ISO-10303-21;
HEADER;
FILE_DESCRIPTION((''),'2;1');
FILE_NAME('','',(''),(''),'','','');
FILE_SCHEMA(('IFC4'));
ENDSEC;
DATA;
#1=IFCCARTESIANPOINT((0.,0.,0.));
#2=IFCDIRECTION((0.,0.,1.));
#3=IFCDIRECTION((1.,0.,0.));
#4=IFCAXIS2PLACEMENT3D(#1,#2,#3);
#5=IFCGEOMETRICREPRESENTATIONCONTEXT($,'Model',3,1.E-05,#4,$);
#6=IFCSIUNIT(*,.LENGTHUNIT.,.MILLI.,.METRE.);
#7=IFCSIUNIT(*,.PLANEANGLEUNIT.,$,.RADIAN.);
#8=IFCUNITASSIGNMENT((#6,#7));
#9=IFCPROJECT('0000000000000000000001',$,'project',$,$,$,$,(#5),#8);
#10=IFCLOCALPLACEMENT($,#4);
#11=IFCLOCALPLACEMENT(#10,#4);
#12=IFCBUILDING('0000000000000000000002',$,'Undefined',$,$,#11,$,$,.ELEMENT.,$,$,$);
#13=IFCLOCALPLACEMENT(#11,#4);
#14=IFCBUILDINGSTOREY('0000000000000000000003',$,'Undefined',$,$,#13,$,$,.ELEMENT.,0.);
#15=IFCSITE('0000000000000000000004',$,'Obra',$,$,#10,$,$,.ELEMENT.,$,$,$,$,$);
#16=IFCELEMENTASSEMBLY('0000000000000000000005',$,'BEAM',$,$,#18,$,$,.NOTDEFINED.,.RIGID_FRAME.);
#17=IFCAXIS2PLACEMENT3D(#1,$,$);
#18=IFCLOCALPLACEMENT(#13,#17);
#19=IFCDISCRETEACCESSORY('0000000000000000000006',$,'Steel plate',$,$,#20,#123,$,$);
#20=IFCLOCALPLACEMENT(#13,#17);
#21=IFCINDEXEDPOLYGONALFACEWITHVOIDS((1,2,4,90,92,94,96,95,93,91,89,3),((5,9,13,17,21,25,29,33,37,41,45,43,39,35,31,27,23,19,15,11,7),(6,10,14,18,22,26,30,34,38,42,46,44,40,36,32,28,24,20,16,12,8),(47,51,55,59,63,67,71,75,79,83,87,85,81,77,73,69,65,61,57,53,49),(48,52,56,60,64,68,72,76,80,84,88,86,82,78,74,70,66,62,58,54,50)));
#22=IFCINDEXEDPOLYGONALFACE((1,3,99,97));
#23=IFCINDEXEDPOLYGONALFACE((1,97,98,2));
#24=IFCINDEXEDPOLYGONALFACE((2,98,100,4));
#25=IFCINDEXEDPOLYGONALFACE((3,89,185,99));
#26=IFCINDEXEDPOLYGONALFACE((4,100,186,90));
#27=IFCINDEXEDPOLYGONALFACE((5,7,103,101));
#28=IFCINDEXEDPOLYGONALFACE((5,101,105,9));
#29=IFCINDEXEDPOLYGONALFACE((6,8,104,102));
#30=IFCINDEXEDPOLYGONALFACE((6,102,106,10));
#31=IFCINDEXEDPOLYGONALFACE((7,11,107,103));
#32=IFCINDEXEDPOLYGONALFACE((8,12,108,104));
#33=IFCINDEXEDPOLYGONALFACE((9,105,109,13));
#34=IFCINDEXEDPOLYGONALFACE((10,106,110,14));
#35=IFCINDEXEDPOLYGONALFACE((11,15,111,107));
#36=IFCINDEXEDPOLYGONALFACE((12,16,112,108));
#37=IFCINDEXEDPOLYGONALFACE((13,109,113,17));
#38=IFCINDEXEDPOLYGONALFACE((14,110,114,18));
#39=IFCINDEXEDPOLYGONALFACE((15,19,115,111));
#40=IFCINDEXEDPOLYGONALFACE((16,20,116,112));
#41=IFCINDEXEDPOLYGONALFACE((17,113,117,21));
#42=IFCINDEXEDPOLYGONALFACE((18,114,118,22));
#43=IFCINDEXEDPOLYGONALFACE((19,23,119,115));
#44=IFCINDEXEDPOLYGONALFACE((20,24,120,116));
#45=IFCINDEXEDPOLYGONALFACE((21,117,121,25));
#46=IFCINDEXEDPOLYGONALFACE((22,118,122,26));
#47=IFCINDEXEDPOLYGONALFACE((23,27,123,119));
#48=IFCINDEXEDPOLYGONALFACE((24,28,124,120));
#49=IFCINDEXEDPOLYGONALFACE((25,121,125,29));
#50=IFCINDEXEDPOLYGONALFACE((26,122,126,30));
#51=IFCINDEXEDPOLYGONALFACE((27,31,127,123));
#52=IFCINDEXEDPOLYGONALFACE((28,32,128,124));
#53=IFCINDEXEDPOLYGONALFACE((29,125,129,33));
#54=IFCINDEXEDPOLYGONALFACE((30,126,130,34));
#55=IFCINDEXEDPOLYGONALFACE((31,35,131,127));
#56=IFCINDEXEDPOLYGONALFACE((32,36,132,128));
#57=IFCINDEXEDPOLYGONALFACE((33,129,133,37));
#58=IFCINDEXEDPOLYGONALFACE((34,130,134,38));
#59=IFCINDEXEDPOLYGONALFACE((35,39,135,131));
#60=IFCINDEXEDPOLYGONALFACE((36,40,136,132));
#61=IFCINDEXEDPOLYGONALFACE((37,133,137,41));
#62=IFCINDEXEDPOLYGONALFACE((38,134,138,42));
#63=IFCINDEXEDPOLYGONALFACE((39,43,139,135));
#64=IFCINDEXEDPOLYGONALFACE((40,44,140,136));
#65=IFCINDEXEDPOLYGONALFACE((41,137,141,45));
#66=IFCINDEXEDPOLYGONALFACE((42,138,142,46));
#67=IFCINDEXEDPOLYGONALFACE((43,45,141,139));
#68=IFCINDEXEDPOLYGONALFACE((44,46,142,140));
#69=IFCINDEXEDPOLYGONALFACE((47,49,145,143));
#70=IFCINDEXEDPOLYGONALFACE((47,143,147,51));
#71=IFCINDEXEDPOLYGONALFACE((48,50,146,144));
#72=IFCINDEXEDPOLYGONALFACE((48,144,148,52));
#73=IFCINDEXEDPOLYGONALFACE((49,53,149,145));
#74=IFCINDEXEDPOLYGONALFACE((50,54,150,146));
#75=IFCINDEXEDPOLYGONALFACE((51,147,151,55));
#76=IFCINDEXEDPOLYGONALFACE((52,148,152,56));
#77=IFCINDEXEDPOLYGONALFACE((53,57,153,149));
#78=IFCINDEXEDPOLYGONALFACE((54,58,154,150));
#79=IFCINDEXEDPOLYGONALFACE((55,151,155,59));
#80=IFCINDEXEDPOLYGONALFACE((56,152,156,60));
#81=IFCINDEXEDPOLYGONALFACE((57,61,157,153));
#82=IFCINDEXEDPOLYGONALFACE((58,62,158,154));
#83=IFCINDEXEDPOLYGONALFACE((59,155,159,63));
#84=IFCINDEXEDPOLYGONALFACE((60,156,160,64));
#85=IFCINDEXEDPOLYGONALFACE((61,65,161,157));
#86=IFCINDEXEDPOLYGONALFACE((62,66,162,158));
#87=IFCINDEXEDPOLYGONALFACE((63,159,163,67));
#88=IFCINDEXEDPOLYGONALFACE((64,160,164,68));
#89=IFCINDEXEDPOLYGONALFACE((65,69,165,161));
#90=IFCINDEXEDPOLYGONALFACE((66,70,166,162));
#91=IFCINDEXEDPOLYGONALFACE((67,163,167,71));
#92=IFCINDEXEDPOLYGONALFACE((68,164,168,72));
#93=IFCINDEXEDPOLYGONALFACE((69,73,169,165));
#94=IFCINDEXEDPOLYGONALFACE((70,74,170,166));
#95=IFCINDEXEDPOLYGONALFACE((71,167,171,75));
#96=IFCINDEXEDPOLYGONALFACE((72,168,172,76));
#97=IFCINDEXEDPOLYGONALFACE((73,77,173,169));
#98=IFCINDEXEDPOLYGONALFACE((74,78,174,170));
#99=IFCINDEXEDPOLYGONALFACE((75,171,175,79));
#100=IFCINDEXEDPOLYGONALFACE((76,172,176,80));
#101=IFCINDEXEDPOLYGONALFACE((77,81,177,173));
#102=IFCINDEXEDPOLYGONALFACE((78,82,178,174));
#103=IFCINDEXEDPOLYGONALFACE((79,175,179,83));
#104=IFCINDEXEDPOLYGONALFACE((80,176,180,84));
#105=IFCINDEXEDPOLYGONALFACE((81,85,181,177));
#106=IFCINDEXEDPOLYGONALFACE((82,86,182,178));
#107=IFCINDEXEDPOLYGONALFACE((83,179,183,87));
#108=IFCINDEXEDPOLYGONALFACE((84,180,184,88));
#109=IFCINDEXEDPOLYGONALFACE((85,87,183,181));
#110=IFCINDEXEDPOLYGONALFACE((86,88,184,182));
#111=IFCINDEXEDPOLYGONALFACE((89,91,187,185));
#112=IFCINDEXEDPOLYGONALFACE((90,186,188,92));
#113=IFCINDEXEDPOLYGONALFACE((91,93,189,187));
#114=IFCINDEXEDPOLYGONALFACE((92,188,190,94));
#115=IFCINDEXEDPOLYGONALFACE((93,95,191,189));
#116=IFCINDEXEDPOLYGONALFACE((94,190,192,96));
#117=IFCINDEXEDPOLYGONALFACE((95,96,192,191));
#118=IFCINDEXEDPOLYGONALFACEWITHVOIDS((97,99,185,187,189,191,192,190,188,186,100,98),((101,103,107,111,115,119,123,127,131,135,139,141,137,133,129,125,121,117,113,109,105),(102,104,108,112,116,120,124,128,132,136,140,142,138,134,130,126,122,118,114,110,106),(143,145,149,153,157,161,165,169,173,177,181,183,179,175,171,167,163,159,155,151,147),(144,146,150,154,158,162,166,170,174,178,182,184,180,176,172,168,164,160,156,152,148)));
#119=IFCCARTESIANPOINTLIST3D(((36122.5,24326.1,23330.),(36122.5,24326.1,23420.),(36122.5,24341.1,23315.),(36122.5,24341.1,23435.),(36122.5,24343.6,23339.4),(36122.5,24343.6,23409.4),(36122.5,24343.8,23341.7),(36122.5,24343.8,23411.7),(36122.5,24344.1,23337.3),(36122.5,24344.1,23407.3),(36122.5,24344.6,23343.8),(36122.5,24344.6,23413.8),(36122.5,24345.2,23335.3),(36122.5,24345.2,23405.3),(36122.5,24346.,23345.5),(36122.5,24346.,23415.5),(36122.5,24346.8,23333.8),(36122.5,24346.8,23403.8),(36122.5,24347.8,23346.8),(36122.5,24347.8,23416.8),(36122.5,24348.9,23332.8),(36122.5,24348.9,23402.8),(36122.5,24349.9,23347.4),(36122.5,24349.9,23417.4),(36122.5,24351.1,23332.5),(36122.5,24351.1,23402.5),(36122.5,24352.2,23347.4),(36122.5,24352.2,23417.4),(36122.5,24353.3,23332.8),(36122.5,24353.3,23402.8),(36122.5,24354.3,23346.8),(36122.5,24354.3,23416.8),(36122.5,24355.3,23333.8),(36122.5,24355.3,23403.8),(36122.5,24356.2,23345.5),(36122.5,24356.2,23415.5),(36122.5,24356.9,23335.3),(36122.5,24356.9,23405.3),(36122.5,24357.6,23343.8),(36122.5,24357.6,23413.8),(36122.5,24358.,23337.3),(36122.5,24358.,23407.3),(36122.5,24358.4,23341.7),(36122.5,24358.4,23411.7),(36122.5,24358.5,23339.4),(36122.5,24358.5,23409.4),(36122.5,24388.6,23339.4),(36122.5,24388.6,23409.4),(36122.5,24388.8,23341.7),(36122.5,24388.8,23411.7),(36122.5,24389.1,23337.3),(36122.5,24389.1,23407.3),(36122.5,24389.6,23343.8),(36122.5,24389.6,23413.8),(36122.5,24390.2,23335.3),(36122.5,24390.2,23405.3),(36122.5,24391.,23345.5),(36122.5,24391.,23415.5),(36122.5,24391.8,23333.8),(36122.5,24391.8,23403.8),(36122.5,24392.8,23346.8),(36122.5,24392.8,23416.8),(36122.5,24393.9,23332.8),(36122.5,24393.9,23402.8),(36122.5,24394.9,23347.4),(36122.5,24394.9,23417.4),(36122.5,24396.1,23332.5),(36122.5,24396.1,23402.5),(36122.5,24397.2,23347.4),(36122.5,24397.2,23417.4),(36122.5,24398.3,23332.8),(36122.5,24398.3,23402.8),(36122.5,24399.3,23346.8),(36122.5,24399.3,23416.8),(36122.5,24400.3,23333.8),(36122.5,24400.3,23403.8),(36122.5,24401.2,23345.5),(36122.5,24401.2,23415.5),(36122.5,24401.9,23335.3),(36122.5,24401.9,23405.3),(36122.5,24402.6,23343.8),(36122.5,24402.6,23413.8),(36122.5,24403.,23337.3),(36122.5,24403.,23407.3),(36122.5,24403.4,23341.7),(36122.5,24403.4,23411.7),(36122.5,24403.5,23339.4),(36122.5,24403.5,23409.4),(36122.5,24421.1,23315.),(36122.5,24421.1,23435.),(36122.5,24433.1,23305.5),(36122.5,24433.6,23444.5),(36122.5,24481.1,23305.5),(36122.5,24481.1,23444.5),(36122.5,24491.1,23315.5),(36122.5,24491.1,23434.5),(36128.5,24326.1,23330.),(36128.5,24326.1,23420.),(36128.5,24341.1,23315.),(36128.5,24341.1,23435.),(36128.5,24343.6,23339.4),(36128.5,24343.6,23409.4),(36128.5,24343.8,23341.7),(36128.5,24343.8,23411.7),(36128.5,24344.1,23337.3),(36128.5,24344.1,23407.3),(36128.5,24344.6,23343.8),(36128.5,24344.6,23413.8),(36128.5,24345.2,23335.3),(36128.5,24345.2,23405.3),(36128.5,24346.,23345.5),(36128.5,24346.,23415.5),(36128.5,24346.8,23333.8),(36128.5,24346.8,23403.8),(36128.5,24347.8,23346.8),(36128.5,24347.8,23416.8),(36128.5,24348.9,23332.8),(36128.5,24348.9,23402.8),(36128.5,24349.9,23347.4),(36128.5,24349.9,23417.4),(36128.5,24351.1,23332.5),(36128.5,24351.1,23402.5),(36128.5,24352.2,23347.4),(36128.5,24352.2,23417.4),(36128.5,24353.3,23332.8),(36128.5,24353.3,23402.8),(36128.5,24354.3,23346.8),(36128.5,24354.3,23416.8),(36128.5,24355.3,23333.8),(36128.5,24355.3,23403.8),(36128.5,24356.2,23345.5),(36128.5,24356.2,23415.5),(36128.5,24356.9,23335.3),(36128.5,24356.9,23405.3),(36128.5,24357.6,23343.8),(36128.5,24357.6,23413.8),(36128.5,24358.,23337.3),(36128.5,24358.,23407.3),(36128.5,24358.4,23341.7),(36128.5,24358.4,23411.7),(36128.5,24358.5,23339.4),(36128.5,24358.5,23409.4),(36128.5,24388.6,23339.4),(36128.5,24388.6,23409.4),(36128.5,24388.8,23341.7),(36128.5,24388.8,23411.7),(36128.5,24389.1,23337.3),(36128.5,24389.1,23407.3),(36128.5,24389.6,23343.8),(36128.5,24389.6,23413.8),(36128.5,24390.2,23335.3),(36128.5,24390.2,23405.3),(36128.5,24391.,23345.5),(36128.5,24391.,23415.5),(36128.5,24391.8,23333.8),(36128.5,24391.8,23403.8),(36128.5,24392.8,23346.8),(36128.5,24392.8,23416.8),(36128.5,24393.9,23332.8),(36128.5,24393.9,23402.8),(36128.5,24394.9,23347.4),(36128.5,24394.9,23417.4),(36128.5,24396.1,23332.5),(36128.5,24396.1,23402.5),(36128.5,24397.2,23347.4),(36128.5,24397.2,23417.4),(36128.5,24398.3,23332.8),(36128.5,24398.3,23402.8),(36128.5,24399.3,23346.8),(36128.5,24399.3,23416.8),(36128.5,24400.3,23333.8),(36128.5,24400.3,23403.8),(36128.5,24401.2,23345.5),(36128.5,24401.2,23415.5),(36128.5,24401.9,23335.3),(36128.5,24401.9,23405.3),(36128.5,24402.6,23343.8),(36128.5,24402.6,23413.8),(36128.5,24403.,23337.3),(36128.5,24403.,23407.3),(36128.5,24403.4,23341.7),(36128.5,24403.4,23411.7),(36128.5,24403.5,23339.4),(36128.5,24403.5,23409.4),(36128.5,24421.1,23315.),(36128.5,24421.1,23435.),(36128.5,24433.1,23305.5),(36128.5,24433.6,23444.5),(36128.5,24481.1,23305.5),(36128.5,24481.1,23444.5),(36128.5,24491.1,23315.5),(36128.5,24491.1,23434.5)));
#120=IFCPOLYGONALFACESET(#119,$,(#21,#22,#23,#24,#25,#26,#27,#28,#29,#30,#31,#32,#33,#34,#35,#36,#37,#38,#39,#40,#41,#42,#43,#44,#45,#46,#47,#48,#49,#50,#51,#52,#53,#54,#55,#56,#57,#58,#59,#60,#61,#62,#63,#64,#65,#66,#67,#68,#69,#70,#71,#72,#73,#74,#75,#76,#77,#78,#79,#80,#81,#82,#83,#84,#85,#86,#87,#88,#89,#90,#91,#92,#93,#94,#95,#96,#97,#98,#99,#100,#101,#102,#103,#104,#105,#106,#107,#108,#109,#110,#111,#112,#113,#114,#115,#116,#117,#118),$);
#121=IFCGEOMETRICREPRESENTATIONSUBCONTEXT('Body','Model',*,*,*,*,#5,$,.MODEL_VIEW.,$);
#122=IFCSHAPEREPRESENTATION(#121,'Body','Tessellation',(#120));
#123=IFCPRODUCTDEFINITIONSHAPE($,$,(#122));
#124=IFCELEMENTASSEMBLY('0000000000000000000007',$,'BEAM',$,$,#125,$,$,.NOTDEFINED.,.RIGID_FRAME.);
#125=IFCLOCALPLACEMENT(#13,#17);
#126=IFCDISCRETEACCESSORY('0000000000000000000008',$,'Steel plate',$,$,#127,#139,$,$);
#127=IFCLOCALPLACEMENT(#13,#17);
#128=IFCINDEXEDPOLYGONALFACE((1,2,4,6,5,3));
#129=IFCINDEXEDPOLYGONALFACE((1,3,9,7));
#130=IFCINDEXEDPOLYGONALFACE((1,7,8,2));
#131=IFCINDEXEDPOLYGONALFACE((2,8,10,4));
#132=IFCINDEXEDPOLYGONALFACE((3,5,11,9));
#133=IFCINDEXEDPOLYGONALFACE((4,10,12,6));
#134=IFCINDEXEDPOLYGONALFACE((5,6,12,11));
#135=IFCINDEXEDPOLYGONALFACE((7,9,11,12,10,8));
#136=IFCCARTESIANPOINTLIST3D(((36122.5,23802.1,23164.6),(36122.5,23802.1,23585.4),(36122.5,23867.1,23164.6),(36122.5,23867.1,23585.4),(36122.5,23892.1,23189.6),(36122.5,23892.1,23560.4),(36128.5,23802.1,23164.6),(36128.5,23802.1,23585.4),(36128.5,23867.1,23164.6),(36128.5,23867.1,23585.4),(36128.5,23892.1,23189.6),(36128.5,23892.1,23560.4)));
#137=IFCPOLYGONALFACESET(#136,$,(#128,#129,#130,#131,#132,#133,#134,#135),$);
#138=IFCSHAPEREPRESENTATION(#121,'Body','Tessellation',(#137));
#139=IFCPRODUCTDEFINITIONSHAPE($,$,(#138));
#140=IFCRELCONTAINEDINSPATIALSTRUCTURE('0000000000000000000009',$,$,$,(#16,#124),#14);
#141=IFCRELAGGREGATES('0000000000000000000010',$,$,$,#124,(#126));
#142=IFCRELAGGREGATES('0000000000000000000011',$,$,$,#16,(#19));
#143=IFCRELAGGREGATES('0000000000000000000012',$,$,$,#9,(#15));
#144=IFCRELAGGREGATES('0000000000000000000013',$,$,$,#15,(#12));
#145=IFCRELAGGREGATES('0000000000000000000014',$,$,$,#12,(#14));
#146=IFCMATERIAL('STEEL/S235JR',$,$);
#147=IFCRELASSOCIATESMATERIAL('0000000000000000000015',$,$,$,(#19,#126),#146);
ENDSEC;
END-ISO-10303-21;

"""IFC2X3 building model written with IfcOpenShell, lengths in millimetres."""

from ifc_helpers import new_model, si_unit, frame, origin_with_axes, origin_2d_with_axis, place, context, subcontext, project, spatial, polyline, circle, outline, extrude, source, transform, mapped, material, element, aggregate, save


model = new_model("IFC2X3")

# Units and contexts
model_context = context("Model", 3, precision=1e-05, world=origin_with_axes())
body_context = subcontext(model_context, "Body", "Model", "MODEL_VIEW")
ifc_project = project(units=[si_unit("LENGTHUNIT", "METRE", prefix="MILLI"), si_unit("PLANEANGLEUNIT", "RADIAN")], contexts=[model_context])

# Site, building, storey
site_placement = place(None, origin_with_axes())
site = spatial("IfcSite", under=ifc_project, at=site_placement, Name="Obra", CompositionType="ELEMENT")
building_placement = place(site_placement, origin_with_axes())
building = spatial("IfcBuilding", under=site, at=building_placement, Name="Undefined", CompositionType="ELEMENT")
storey_placement = place(building_placement, origin_with_axes())
storey = spatial("IfcBuildingStorey", under=building, at=storey_placement, Name="Undefined", CompositionType="ELEMENT", Elevation=0.0)

# Element assembly
assembly_1_placement = place(storey_placement, origin_with_axes())
assembly_1 = element("IfcElementAssembly", 1, at=assembly_1_placement, inside=storey, Name="BEAM", AssemblyPlace="NOTDEFINED", PredefinedType="RIGID_FRAME")

# Shared definitions
ifc_material_1 = material(Name="STEEL/S235JR")

# Shared definitions
shared_shape_1 = source(origin_with_axes(), body_context, "Body", "SweptSolid", [
    extrude(circle(Radius=7.5, at=origin_2d_with_axis()), frame((0.0, 2.4, 0.0), z_axis=(0.0, 1.0, 0.0), x_axis=(1.0, 0.0, 0.0)), (0.0, 0.0, 1.0), 6.2),
])

# Discrete accessory, opening
discrete_accessory_1_placement = place(assembly_1_placement, frame((36125.5, 24491.1, 23315.5), z_axis=(-1.0, 0.0, 0.0), x_axis=(0.000001, -0.707107, -0.707107)))
discrete_accessory_1 = element("IfcDiscreteAccessory", 2, at=discrete_accessory_1_placement, material=ifc_material_1, Name="Steel plate", context=body_context, shape_type="SweptSolid", body=[
    extrude(outline(polyline([(0.0, 0.0), (14.1, 0.0), (48.1, 33.9), (49.9, 49.1), (106.4, 105.7), (106.4, 126.9), (42.8, 190.6), (21.6, 190.6), (-35.0, 134.0), (-50.6, 131.9), (-84.1, 98.3), (-84.1, 84.1), (0.0, 0.0)])), frame((0.0, 0.0, -3.0), z_axis=(0.0, 0.0, 1.0), x_axis=(1.0, 0.0, 0.0)), (0.0, 0.0, 1.0), 6.0),
])
opening_1_placement = place(assembly_1_placement, frame((36120.0, 24373.6, 23410.0), z_axis=(0.0, -1.0, 0.0), x_axis=(0.0, 0.0, -1.0)))
element("IfcOpeningElement", 3, at=opening_1_placement, cuts=discrete_accessory_1, ObjectType="Opening", context=body_context, shape_type="MappedRepresentation", body=[
    mapped(shared_shape_1, transform((0.0, 0.0, -22.5))),
    mapped(shared_shape_1, transform((70.0, 0.0, -22.5))),
    mapped(shared_shape_1, transform((0.0, 0.0, 22.5))),
    mapped(shared_shape_1, transform((70.0, 0.0, 22.5))),
])

# Element assembly, discrete accessory
assembly_2_placement = place(storey_placement, origin_with_axes())
assembly_2 = element("IfcElementAssembly", 4, at=assembly_2_placement, inside=storey, Name="BEAM", AssemblyPlace="NOTDEFINED", PredefinedType="RIGID_FRAME")
discrete_accessory_2_placement = place(assembly_2_placement, frame((36125.5, 23892.1, 23164.6), z_axis=(-1.0, 0.0, 0.0), x_axis=(0.0, -1.0, 0.0)))
discrete_accessory_2 = element("IfcDiscreteAccessory", 5, at=discrete_accessory_2_placement, material=ifc_material_1, Name="Steel plate", context=body_context, shape_type="SweptSolid", body=[
    extrude(outline(polyline([(0.0, 25.0), (25.0, 0.0), (90.0, 0.0), (90.0, 420.8), (25.0, 420.8), (0.0, 395.8), (0.0, 25.0)])), frame((0.0, 0.0, -3.0), z_axis=(0.0, 0.0, 1.0), x_axis=(1.0, 0.0, 0.0)), (0.0, 0.0, 1.0), 6.0),
])
aggregate(assembly_2, [discrete_accessory_2])

aggregate(assembly_1, [discrete_accessory_1])

save(model, "model.ifc")
